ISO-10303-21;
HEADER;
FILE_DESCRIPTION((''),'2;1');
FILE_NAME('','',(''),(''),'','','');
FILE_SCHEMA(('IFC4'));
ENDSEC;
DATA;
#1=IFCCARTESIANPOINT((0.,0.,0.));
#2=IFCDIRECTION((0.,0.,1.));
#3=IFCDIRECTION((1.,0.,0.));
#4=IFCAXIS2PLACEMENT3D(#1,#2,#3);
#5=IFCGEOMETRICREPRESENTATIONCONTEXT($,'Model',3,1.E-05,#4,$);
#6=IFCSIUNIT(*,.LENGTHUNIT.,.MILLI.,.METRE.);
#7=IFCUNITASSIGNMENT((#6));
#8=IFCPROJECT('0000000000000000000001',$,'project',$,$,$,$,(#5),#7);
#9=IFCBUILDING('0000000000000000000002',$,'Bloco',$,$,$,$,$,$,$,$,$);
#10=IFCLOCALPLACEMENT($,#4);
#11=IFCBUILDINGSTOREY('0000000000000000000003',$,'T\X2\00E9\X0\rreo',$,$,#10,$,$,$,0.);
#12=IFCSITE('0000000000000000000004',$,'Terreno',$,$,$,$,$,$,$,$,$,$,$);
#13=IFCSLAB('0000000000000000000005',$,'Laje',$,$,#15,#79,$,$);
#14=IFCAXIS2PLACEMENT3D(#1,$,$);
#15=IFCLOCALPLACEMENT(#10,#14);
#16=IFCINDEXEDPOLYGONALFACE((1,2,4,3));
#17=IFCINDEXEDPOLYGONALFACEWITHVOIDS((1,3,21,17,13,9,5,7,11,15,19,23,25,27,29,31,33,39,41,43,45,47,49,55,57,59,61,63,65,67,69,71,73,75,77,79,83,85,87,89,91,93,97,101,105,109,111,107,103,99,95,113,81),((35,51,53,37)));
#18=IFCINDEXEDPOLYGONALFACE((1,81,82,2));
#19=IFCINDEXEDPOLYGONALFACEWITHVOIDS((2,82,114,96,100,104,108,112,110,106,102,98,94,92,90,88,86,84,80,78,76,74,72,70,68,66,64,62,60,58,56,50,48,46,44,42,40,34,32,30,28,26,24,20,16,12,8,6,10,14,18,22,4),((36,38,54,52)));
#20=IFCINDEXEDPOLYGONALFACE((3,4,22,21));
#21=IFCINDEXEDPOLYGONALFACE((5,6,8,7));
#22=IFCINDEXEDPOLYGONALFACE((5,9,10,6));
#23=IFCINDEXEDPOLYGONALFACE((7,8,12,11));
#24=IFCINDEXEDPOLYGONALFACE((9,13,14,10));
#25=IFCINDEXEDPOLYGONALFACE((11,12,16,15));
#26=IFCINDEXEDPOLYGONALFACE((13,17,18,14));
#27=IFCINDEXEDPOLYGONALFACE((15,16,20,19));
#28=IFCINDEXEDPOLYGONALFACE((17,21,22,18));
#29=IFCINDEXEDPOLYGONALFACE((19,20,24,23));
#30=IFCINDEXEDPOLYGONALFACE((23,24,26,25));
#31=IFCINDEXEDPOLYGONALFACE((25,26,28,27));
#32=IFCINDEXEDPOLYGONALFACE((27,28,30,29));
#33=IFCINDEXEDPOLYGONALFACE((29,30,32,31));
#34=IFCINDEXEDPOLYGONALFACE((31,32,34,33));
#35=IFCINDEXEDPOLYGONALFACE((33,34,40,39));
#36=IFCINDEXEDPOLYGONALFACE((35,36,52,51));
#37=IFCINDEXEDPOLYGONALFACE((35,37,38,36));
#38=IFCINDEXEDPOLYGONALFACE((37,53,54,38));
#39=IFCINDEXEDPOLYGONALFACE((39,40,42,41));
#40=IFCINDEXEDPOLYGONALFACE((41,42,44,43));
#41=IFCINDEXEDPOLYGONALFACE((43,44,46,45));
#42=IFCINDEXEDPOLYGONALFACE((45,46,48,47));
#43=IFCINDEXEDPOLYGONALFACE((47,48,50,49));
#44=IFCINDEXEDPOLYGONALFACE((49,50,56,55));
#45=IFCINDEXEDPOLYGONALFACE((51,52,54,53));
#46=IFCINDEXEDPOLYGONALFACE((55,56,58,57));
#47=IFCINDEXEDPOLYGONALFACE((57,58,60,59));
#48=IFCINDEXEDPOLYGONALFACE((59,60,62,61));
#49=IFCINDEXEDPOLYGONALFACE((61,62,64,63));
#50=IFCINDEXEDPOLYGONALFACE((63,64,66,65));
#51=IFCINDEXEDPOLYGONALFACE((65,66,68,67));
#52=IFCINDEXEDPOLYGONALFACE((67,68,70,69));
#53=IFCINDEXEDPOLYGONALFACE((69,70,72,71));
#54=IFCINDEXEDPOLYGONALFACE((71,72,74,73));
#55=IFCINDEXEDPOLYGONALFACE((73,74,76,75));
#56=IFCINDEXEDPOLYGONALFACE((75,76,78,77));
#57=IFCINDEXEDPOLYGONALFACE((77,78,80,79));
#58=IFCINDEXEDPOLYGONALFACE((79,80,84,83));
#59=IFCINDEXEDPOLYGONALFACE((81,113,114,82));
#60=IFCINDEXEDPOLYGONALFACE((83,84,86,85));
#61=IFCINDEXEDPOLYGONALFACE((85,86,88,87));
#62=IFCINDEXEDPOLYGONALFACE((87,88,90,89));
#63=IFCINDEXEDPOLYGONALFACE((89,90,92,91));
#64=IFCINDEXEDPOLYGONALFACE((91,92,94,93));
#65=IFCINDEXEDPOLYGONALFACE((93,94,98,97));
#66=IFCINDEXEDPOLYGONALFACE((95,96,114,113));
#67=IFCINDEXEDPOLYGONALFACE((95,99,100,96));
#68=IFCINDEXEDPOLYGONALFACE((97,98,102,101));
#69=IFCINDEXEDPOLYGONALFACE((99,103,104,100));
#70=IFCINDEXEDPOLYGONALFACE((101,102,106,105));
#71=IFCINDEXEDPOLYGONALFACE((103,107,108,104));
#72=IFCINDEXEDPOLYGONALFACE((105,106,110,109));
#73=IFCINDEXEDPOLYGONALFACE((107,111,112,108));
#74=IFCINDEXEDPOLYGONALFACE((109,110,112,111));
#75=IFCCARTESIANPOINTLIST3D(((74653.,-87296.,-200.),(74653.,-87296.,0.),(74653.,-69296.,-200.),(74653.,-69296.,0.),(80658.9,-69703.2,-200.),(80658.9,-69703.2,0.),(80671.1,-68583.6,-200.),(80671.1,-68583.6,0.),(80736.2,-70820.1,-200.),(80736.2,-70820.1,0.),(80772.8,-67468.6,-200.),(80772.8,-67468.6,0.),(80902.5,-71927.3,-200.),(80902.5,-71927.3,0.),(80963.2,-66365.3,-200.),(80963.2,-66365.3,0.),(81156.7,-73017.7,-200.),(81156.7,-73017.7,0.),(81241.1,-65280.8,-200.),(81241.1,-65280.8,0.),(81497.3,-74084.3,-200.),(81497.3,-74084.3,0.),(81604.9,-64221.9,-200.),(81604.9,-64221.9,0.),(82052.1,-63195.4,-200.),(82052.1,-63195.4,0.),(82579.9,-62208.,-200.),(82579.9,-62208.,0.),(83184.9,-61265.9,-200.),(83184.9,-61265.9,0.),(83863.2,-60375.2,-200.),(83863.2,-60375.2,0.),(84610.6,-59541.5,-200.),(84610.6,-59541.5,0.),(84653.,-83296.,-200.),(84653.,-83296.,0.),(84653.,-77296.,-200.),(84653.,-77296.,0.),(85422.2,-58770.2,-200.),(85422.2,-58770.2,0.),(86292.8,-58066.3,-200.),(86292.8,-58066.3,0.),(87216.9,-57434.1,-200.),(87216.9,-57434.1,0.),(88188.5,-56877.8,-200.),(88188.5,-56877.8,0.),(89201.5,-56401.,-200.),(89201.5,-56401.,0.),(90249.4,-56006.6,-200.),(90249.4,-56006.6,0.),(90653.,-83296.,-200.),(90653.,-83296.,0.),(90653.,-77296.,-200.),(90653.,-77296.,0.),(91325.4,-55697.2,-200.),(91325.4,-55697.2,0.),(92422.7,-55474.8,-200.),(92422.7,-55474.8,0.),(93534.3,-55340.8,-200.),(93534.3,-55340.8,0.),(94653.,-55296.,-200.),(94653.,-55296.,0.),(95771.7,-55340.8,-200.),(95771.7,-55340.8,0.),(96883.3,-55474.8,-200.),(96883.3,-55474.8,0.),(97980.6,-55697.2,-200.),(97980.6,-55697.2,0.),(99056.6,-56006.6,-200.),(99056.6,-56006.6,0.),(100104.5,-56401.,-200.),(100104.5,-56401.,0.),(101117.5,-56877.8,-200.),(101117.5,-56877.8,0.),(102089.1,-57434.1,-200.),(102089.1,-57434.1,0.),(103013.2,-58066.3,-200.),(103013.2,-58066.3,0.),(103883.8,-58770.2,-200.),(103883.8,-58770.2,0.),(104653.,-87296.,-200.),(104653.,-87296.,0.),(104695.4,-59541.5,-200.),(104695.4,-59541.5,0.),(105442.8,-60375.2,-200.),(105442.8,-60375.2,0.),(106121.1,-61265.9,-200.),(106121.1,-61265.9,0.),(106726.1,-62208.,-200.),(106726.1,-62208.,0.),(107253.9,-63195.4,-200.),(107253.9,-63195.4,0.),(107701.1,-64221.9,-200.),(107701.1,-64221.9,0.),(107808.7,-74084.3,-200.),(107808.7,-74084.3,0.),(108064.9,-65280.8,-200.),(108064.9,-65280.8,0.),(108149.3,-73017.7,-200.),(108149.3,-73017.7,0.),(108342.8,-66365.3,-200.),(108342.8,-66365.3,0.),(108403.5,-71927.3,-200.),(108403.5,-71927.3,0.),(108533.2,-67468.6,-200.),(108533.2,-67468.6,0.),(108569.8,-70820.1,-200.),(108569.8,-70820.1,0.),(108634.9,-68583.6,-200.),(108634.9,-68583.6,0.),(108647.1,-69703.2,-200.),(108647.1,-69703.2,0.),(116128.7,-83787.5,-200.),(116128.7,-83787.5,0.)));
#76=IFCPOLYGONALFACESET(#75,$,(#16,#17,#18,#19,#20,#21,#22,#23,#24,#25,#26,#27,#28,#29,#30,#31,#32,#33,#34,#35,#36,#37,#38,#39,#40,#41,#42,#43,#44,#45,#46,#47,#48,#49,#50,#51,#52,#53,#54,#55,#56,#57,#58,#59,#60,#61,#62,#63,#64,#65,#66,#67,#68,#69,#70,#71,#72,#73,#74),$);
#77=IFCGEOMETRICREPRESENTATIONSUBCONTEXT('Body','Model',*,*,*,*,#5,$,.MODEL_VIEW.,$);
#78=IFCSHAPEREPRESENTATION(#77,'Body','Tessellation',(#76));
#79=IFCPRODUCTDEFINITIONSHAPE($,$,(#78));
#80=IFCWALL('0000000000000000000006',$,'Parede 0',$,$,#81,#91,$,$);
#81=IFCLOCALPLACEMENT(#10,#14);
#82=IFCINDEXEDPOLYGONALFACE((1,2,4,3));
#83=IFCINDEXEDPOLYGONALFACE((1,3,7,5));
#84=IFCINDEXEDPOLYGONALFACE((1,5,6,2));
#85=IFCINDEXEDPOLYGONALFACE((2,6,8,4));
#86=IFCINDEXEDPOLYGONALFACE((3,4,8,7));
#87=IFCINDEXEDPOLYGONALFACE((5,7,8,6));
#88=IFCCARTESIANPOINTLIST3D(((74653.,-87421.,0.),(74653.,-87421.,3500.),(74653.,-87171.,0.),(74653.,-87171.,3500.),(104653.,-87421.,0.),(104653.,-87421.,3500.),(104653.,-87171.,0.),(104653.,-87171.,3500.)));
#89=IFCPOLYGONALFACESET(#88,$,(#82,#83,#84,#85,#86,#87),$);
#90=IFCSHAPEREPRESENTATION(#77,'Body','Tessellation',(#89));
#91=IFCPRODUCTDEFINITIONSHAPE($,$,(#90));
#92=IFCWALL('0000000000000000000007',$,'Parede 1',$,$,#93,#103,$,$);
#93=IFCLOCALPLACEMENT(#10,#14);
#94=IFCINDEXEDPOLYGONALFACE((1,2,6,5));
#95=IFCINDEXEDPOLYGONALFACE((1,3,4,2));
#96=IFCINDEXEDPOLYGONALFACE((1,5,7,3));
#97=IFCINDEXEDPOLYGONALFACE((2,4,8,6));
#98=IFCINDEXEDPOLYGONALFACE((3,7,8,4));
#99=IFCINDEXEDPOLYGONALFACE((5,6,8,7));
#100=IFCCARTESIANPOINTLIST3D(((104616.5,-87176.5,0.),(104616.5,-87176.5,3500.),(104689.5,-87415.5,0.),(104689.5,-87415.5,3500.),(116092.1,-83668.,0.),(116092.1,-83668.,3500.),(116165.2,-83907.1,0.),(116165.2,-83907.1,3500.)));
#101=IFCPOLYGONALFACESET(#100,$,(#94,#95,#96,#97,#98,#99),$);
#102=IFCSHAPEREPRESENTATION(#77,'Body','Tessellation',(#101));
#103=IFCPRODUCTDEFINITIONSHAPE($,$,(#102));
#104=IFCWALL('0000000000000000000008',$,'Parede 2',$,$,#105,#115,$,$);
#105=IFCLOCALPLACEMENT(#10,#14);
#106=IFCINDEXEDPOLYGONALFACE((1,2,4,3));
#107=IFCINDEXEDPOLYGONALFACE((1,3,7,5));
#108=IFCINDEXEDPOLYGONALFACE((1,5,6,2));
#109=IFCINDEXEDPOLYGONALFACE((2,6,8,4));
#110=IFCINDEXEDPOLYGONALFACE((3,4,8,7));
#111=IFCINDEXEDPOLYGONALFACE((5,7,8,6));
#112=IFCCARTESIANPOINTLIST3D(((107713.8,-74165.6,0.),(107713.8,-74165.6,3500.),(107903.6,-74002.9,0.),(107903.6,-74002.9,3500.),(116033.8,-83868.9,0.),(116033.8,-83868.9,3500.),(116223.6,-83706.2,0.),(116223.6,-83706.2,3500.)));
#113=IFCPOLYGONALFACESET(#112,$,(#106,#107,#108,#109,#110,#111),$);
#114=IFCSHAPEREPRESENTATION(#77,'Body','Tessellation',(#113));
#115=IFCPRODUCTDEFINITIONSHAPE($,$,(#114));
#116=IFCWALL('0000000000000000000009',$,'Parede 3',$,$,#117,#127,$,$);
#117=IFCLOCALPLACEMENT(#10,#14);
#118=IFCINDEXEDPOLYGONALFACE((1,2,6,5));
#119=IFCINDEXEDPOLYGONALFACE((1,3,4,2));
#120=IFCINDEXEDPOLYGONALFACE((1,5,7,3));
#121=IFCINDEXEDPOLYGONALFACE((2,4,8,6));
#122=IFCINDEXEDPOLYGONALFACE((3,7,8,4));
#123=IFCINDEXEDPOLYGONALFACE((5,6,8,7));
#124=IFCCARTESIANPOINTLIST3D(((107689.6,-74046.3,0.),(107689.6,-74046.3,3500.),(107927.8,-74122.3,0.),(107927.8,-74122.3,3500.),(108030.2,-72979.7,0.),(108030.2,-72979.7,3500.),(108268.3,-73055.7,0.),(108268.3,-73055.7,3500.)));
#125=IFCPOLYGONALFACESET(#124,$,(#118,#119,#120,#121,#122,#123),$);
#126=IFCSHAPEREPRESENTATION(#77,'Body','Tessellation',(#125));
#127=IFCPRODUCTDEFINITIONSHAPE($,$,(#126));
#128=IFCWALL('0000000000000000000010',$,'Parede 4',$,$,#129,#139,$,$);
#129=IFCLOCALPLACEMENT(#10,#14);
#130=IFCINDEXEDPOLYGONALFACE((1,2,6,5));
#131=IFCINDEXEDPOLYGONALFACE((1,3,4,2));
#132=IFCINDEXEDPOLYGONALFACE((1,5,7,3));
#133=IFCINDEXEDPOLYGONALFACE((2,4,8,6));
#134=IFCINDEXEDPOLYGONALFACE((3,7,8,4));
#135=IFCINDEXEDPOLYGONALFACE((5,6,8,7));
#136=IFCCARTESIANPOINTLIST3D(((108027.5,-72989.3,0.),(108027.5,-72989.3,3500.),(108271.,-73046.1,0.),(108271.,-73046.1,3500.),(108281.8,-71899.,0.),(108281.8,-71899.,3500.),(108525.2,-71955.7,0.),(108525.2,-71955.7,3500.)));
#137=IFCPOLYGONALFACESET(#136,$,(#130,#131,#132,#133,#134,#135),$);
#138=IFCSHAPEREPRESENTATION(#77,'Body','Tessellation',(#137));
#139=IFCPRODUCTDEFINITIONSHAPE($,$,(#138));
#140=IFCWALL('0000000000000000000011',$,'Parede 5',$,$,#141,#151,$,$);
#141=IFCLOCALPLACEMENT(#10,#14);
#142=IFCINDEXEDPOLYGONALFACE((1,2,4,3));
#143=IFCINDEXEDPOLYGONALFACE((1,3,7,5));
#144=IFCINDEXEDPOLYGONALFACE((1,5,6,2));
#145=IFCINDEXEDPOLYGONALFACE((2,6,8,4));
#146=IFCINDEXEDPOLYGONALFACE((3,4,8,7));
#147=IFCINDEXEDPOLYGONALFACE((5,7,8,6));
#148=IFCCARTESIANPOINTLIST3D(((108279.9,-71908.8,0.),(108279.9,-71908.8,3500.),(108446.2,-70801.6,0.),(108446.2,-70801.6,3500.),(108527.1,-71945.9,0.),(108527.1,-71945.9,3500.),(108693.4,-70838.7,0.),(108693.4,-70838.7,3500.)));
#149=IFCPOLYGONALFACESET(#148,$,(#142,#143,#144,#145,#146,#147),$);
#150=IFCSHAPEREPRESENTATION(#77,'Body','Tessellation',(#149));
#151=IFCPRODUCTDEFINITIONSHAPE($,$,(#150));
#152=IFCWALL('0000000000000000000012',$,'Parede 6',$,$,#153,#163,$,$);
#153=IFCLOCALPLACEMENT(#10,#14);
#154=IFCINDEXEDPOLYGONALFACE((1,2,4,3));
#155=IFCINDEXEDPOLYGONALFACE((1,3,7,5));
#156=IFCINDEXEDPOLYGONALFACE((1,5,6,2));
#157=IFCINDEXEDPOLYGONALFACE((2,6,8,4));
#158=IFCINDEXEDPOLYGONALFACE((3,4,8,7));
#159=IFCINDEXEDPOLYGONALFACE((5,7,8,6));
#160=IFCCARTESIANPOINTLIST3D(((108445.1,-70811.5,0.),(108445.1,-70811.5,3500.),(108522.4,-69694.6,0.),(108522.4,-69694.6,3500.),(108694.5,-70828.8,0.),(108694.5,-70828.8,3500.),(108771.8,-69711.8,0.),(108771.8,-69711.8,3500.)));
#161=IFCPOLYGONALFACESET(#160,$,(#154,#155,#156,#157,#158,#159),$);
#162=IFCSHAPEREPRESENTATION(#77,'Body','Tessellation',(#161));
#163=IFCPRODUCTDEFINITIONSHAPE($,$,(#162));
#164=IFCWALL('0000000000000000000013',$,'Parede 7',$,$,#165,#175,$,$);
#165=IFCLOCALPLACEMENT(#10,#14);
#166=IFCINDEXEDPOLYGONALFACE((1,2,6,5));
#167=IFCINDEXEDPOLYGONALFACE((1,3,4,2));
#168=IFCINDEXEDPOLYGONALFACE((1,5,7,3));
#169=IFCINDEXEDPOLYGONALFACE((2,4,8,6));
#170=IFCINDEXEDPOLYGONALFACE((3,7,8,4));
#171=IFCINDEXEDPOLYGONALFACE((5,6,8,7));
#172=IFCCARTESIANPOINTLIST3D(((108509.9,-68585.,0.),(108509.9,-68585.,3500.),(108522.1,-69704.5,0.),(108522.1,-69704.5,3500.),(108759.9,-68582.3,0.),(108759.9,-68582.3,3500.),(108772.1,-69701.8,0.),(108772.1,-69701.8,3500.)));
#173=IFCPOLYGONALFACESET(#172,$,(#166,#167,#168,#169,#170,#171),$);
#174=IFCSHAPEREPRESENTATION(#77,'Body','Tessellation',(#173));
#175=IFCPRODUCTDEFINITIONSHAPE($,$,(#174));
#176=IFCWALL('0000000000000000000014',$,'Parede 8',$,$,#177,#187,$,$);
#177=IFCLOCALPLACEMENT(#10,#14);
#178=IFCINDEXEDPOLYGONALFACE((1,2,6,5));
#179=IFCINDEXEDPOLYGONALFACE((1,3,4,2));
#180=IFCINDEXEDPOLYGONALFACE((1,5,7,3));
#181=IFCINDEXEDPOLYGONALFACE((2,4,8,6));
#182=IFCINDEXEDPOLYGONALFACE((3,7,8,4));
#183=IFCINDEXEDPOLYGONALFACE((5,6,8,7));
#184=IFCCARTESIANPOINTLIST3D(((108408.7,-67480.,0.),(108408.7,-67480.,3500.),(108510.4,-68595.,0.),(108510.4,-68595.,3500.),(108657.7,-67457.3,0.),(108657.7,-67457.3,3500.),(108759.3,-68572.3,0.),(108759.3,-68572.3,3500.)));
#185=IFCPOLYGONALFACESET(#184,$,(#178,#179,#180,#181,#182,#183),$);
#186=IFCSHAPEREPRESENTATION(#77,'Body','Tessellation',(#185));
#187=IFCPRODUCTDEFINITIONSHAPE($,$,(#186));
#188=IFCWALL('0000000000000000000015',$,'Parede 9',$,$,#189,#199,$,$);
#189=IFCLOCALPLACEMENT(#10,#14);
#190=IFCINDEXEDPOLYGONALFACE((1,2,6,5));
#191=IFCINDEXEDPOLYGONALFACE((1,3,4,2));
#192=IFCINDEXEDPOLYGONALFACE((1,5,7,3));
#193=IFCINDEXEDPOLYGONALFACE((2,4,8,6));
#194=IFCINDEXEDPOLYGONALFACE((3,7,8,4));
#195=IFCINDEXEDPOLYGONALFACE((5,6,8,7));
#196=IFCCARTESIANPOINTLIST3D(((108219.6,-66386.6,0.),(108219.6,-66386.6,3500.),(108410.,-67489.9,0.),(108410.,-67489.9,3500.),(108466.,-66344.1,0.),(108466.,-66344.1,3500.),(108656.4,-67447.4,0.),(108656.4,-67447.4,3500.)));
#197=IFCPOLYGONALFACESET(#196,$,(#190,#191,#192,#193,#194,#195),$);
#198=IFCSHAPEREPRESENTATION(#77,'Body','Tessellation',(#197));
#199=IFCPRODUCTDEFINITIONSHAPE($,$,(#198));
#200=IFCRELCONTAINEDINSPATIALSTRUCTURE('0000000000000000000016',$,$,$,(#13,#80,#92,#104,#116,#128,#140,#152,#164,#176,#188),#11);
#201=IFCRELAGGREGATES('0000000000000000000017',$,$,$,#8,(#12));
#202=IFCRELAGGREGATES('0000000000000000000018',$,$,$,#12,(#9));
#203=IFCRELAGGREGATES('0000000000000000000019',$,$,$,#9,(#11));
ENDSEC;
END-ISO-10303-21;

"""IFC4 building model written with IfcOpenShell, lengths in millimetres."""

from ifc_helpers import new_model, si_unit, frame, origin, origin_with_axes, place, context, subcontext, project, spatial, polyline, outline, extrude, element, save


model = new_model("IFC4")

# Units and contexts
model_context = context("Model", 3, precision=1e-05, world=origin_with_axes())
body_context = subcontext(model_context, "Body", "Model", "MODEL_VIEW")
ifc_project = project(units=[si_unit("LENGTHUNIT", "METRE", prefix="MILLI")], contexts=[model_context])

# Site, building, storey
site = spatial("IfcSite", under=ifc_project, Name="Terreno")
building = spatial("IfcBuilding", under=site, Name="Bloco")
storey_placement = place(None, origin_with_axes())
storey = spatial("IfcBuildingStorey", under=building, at=storey_placement, Name="Térreo", Elevation=0.0)

# Slab
slab_placement = place(storey_placement, frame((0.0, 0.0, -200.0), z_axis=(0.0, 0.0, 1.0), x_axis=(1.0, 0.0, 0.0)))
element("IfcSlab", 1, at=slab_placement, inside=storey, Name="Laje", context=body_context, shape_type="SweptSolid", body=[
    extrude(outline(polyline([(74653.0, -87296.0), (104653.0, -87296.0), (116128.7, -83787.5), (107808.7, -74084.3), (108149.3, -73017.7), (108403.5, -71927.3), (108569.8, -70820.1), (108647.1, -69703.2), (108634.9, -68583.6), (108533.2, -67468.6), (108342.8, -66365.3), (108064.9, -65280.8), (107701.1, -64221.9), (107253.9, -63195.4), (106726.1, -62208.0), (106121.1, -61265.9), (105442.8, -60375.2), (104695.4, -59541.5), (103883.8, -58770.2), (103013.2, -58066.3), (102089.1, -57434.1), (101117.5, -56877.8), (100104.5, -56401.0), (99056.6, -56006.6), (97980.6, -55697.2), (96883.3, -55474.8), (95771.7, -55340.8), (94653.0, -55296.0), (93534.3, -55340.8), (92422.7, -55474.8), (91325.4, -55697.2), (90249.4, -56006.6), (89201.5, -56401.0), (88188.5, -56877.8), (87216.9, -57434.1), (86292.8, -58066.3), (85422.2, -58770.2), (84610.6, -59541.5), (83863.2, -60375.2), (83184.9, -61265.9), (82579.9, -62208.0), (82052.1, -63195.4), (81604.9, -64221.9), (81241.1, -65280.8), (80963.2, -66365.3), (80772.8, -67468.6), (80671.1, -68583.6), (80658.9, -69703.2), (80736.2, -70820.1), (80902.5, -71927.3), (81156.7, -73017.7), (81497.3, -74084.3), (74653.0, -69296.0), (74653.0, -87296.0)]), holes=[polyline([(84653.0, -83296.0), (90653.0, -83296.0), (90653.0, -77296.0), (84653.0, -77296.0), (84653.0, -83296.0)])]), origin(), (0.0, 0.0, 1.0), 200.0),
])

# Walls
wall_1_placement = place(storey_placement, origin_with_axes())
element("IfcWall", 2, at=wall_1_placement, inside=storey, Name="Parede 0", context=body_context, shape_type="SweptSolid", body=[
    extrude(outline(polyline([(74653.0, -87171.0), (104653.0, -87171.0), (104653.0, -87421.0), (74653.0, -87421.0), (74653.0, -87171.0)])), origin(), (0.0, 0.0, 1.0), 3500.0),
])
wall_2_placement = place(storey_placement, origin_with_axes())
element("IfcWall", 3, at=wall_2_placement, inside=storey, Name="Parede 1", context=body_context, shape_type="SweptSolid", body=[
    extrude(outline(polyline([(104616.5, -87176.5), (116092.1, -83668.0), (116165.2, -83907.1), (104689.5, -87415.5), (104616.5, -87176.5)])), origin(), (0.0, 0.0, 1.0), 3500.0),
])
wall_3_placement = place(storey_placement, origin_with_axes())
element("IfcWall", 4, at=wall_3_placement, inside=storey, Name="Parede 2", context=body_context, shape_type="SweptSolid", body=[
    extrude(outline(polyline([(116033.8, -83868.9), (107713.8, -74165.6), (107903.6, -74002.9), (116223.6, -83706.2), (116033.8, -83868.9)])), origin(), (0.0, 0.0, 1.0), 3500.0),
])
wall_4_placement = place(storey_placement, origin_with_axes())
element("IfcWall", 5, at=wall_4_placement, inside=storey, Name="Parede 3", context=body_context, shape_type="SweptSolid", body=[
    extrude(outline(polyline([(107689.6, -74046.3), (108030.2, -72979.7), (108268.3, -73055.7), (107927.8, -74122.3), (107689.6, -74046.3)])), origin(), (0.0, 0.0, 1.0), 3500.0),
])
wall_5_placement = place(storey_placement, origin_with_axes())
element("IfcWall", 6, at=wall_5_placement, inside=storey, Name="Parede 4", context=body_context, shape_type="SweptSolid", body=[
    extrude(outline(polyline([(108027.5, -72989.3), (108281.8, -71899.0), (108525.2, -71955.7), (108271.0, -73046.1), (108027.5, -72989.3)])), origin(), (0.0, 0.0, 1.0), 3500.0),
])
wall_6_placement = place(storey_placement, origin_with_axes())
element("IfcWall", 7, at=wall_6_placement, inside=storey, Name="Parede 5", context=body_context, shape_type="SweptSolid", body=[
    extrude(outline(polyline([(108279.9, -71908.8), (108446.2, -70801.6), (108693.4, -70838.7), (108527.1, -71945.9), (108279.9, -71908.8)])), origin(), (0.0, 0.0, 1.0), 3500.0),
])
wall_7_placement = place(storey_placement, origin_with_axes())
element("IfcWall", 8, at=wall_7_placement, inside=storey, Name="Parede 6", context=body_context, shape_type="SweptSolid", body=[
    extrude(outline(polyline([(108445.1, -70811.5), (108522.4, -69694.6), (108771.8, -69711.8), (108694.5, -70828.8), (108445.1, -70811.5)])), origin(), (0.0, 0.0, 1.0), 3500.0),
])
wall_8_placement = place(storey_placement, origin_with_axes())
element("IfcWall", 9, at=wall_8_placement, inside=storey, Name="Parede 7", context=body_context, shape_type="SweptSolid", body=[
    extrude(outline(polyline([(108522.1, -69704.5), (108509.9, -68585.0), (108759.9, -68582.3), (108772.1, -69701.8), (108522.1, -69704.5)])), origin(), (0.0, 0.0, 1.0), 3500.0),
])
wall_9_placement = place(storey_placement, origin_with_axes())
element("IfcWall", 10, at=wall_9_placement, inside=storey, Name="Parede 8", context=body_context, shape_type="SweptSolid", body=[
    extrude(outline(polyline([(108510.4, -68595.0), (108408.7, -67480.0), (108657.7, -67457.3), (108759.3, -68572.3), (108510.4, -68595.0)])), origin(), (0.0, 0.0, 1.0), 3500.0),
])
wall_10_placement = place(storey_placement, origin_with_axes())
element("IfcWall", 11, at=wall_10_placement, inside=storey, Name="Parede 9", context=body_context, shape_type="SweptSolid", body=[
    extrude(outline(polyline([(108410.0, -67489.9), (108219.6, -66386.6), (108466.0, -66344.1), (108656.4, -67447.4), (108410.0, -67489.9)])), origin(), (0.0, 0.0, 1.0), 3500.0),
])

save(model, "model.ifc")
